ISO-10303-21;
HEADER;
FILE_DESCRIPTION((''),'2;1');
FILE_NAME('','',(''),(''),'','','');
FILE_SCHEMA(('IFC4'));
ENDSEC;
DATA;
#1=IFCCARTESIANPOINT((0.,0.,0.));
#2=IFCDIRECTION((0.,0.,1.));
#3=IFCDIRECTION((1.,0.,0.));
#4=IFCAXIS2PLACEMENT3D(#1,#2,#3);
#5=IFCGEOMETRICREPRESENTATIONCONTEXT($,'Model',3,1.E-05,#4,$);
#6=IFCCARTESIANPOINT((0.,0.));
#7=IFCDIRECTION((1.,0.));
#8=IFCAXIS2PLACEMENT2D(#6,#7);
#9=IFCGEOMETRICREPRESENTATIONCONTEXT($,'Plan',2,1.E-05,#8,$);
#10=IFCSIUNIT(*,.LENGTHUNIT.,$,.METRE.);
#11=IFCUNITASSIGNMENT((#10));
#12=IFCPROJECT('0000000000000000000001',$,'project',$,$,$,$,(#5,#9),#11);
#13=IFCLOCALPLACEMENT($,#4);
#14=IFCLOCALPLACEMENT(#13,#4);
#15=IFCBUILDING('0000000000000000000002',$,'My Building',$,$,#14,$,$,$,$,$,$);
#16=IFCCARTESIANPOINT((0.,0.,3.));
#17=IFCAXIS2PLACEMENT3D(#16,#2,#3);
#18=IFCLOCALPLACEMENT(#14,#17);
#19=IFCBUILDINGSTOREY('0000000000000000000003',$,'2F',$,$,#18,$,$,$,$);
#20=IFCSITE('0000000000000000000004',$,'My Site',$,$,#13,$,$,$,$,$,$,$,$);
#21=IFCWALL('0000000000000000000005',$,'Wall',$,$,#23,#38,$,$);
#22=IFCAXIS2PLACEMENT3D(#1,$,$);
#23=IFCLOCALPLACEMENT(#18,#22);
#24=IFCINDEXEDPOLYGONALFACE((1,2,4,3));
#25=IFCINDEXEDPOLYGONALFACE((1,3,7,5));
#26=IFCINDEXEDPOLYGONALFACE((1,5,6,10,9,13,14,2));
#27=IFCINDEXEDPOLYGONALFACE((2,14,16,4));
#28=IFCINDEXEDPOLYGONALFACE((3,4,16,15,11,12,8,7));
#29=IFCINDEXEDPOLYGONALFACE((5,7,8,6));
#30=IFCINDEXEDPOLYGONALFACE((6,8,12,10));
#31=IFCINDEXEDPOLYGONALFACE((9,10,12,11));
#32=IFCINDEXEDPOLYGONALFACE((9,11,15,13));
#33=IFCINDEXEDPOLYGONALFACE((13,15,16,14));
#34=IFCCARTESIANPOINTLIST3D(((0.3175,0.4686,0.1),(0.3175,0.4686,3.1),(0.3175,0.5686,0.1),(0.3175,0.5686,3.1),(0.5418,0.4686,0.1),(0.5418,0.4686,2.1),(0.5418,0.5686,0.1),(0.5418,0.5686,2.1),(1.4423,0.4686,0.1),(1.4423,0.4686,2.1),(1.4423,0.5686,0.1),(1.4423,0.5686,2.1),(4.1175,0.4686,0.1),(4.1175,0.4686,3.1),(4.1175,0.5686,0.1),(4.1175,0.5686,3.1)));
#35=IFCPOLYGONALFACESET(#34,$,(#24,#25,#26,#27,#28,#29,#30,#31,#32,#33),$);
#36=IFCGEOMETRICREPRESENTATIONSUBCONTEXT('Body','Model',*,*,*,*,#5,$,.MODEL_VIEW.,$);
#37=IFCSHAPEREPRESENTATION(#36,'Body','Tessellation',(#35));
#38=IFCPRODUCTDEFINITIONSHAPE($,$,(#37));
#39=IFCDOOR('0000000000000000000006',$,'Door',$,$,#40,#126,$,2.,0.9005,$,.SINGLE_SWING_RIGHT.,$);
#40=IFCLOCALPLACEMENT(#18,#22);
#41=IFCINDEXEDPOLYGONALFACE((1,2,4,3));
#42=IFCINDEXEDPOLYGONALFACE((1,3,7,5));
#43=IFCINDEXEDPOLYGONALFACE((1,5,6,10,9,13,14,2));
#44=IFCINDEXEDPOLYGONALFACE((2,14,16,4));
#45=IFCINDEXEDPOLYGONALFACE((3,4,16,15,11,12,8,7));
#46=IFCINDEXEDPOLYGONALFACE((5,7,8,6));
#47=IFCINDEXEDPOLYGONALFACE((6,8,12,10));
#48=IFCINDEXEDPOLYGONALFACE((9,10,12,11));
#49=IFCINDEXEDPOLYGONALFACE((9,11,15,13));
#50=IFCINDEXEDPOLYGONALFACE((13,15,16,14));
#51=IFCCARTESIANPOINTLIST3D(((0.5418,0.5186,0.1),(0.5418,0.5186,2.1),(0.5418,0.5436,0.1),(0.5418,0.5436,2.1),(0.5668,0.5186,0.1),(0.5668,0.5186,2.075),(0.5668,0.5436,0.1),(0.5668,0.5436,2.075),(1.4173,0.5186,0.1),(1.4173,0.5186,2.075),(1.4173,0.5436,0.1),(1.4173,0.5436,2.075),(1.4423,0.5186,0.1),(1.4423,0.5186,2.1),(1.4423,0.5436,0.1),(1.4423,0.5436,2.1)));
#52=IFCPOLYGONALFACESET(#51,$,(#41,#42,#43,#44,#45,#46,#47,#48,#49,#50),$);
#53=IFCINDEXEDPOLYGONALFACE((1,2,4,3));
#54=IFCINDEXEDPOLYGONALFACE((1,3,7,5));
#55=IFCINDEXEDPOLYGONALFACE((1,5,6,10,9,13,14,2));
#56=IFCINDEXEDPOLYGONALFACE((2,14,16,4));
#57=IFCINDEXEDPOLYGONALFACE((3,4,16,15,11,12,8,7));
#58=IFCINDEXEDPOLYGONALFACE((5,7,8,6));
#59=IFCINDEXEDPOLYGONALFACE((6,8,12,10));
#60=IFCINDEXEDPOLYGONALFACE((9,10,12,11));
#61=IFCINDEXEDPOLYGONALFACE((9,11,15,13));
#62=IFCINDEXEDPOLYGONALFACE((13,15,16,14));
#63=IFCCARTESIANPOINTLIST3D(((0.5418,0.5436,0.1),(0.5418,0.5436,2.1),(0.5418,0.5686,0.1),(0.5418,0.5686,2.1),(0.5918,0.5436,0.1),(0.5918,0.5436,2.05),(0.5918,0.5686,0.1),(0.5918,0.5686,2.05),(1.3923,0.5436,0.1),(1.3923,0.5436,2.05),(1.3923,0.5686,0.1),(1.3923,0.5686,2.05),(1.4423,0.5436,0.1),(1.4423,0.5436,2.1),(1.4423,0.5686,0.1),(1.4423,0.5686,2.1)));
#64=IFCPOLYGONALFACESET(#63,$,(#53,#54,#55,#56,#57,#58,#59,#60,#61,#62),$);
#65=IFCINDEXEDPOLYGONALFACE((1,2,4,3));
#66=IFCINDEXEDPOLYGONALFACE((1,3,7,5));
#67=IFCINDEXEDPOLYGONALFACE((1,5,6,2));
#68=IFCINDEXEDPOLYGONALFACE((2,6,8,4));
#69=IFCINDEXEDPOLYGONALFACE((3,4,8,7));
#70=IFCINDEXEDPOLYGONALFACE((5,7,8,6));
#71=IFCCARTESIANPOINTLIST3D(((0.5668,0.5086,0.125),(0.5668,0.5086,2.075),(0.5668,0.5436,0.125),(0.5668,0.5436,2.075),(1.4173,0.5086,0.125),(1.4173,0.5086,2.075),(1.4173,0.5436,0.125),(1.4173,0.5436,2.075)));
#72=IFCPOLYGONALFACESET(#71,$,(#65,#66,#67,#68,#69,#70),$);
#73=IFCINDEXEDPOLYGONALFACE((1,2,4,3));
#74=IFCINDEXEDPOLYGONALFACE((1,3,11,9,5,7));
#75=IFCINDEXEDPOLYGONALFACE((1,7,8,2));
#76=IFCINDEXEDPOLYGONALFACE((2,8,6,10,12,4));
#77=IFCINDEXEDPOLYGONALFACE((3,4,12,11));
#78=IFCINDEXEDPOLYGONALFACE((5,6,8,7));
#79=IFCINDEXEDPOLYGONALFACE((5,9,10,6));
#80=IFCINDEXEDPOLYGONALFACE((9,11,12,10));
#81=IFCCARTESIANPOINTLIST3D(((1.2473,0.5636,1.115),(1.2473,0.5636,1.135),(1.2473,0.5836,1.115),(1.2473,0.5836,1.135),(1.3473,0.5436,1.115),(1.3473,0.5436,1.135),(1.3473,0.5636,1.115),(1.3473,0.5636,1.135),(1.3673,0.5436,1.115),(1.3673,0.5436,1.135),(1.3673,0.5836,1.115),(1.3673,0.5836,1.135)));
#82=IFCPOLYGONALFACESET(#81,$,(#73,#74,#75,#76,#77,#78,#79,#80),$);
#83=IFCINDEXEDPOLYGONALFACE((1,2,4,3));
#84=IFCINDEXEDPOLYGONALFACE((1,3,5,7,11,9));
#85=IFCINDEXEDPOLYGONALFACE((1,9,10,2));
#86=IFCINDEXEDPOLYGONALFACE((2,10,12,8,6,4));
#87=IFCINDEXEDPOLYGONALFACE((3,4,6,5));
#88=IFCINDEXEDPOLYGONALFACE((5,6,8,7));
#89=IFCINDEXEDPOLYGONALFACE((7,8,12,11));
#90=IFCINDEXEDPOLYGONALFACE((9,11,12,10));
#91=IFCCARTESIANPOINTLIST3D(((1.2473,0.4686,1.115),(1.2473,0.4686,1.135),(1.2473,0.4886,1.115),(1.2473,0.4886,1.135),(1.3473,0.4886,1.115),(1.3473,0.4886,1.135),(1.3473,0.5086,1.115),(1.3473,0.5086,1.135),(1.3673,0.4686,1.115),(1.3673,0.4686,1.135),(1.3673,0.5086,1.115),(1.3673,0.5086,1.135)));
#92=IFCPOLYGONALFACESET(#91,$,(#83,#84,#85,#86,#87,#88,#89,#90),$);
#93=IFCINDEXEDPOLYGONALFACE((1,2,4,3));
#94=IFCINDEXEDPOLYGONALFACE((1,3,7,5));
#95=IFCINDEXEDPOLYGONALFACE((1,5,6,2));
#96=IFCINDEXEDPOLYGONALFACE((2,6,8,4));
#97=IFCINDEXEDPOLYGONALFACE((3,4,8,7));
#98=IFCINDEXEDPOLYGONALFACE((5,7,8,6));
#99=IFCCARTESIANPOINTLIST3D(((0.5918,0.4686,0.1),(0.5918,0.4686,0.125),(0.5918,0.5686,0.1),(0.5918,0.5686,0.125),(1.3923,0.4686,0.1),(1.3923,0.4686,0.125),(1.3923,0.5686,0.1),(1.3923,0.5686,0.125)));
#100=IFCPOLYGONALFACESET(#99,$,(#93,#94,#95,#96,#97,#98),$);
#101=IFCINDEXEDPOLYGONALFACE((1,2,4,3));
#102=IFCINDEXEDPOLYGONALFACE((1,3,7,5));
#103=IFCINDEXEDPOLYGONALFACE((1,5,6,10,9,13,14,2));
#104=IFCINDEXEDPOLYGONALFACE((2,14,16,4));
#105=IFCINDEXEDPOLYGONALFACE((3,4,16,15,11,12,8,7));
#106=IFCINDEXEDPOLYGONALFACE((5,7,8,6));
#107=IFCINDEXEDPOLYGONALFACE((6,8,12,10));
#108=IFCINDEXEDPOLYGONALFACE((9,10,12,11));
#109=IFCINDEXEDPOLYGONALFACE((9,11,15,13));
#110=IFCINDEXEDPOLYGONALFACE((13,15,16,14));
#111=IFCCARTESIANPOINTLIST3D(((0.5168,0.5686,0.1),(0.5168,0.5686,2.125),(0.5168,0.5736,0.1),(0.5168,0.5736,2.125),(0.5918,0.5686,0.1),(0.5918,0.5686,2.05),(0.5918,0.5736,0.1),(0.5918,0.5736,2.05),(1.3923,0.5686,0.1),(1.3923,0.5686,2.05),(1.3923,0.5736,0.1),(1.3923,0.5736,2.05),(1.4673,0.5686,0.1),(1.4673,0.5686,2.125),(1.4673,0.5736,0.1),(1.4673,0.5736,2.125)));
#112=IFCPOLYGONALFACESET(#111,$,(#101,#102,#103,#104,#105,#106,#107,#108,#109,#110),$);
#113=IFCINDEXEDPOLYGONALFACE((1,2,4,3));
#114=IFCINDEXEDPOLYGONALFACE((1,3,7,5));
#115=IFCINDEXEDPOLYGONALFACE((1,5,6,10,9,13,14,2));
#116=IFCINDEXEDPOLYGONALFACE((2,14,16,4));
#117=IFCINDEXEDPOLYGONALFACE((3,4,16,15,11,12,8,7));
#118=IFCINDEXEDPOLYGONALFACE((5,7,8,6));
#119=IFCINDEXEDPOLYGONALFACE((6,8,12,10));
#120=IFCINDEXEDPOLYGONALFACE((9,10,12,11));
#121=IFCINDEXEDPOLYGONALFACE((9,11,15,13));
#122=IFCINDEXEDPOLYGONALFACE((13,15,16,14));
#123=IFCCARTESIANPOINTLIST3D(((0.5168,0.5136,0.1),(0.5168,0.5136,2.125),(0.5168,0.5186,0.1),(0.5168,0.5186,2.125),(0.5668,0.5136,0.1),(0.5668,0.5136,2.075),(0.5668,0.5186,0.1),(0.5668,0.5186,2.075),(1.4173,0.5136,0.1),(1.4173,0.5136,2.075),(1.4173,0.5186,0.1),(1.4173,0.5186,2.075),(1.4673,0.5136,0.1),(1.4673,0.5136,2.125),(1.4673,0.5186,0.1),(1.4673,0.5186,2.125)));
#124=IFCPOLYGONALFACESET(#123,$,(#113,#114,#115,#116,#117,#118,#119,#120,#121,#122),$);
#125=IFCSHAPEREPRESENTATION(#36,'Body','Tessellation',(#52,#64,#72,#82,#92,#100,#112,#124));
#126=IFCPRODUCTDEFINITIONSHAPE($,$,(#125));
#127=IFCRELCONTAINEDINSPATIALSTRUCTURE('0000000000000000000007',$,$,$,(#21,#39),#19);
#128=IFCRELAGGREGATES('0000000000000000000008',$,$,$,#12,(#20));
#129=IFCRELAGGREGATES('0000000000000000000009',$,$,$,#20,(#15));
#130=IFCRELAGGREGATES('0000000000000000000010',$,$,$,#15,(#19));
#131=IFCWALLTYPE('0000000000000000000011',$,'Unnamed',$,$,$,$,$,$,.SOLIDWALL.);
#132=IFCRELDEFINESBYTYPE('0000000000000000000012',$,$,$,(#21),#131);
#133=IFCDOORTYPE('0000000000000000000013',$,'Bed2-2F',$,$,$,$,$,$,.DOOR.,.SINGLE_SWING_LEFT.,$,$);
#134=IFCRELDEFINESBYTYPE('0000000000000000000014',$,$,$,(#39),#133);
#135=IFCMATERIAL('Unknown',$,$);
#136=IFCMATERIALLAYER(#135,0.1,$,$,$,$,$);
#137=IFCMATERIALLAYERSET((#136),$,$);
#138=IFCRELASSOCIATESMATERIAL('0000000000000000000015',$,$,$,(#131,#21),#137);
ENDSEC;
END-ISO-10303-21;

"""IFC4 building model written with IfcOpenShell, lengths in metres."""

from ifc_helpers import new_model, entity, si_unit, frame, origin_with_axes, origin_2d_with_axis, place, context, subcontext, project, spatial, line, indexed_curve, outline, extrude, shape, source, transform, mapped, material, layer, layer_set, layer_usage, type_object, type_shapes, element, fill, save


model = new_model("IFC4")

# Units and contexts
model_context = context("Model", 3, precision=1e-05, world=origin_with_axes())
plan_context = context("Plan", 2, precision=1e-05, world=origin_2d_with_axis())
body_context_1 = subcontext(model_context, "Body", "Model", "MODEL_VIEW")
body_context_2 = subcontext(plan_context, "Body", "Plan", "PLAN_VIEW")
ifc_project = project(units=[si_unit("LENGTHUNIT", "METRE")], contexts=[model_context, plan_context])

# Site, building, storey
site_placement = place(None, origin_with_axes())
site = spatial("IfcSite", under=ifc_project, at=site_placement, Name="My Site")
building_placement = place(site_placement, origin_with_axes())
building = spatial("IfcBuilding", under=site, at=building_placement, Name="My Building")
storey_placement = place(building_placement, frame((0.0, 0.0, 3.0), z_axis=(0.0, 0.0, 1.0), x_axis=(1.0, 0.0, 0.0)))
storey = spatial("IfcBuildingStorey", under=building, at=storey_placement, Name="2F")

# Shared definitions
ifc_material = material(Name="Unknown")

# Shared definitions
ifc_layer_1 = layer(ifc_material, 0.1)
ifc_layer_set_1 = layer_set([ifc_layer_1])
wall_type = type_object("IfcWallType", Name="Unnamed", PredefinedType="SOLIDWALL", material=ifc_layer_set_1)

# Wall, opening, door
ifc_layer_usage_1 = layer_usage(ifc_layer_set_1, "AXIS2", "POSITIVE", 0.0)
wall_1_placement = place(storey_placement, frame((0.2175, 0.4686, 0.1), z_axis=(0.0, 0.0, 1.0), x_axis=(1.0, 0.0, 0.0)))
wall_1 = element("IfcWall", 1, at=wall_1_placement, inside=storey, type_object=wall_type, material=ifc_layer_usage_1, Name="Wall", context=body_context_1, shape_type="SweptSolid", body=[
    extrude(outline(indexed_curve([(0.1, 0.0), (0.1, 0.1), (3.9, 0.1), (3.9, 0.0)], segments=[line(1, 2, 3, 4, 1)])), origin_with_axes(), (0.0, 0.0, 1.0), 3.0),
])
shared_shape_1 = source(origin_with_axes(), body_context_1, "Body", "SweptSolid", [
    extrude(outline(indexed_curve([(0.0, 0.0), (0.9005, 0.0), (0.9005, 2.0), (0.0, 2.0)], segments=[line(1, 2, 3, 4, 1)])), frame((0.0, -0.6, 0.0), z_axis=(0.0, -1.0, 0.0), x_axis=(1.0, 0.0, 0.0)), (0.0, 0.0, -1.0), 1.2),
])
opening_1_placement = place(wall_1_placement, frame((1.2248, 0.1, 0.0), z_axis=(0.0, 0.0, 1.0), x_axis=(-1.0, 0.0, 0.0)))
opening_1 = element("IfcOpeningElement", 2, at=opening_1_placement, cuts=wall_1, PredefinedType="OPENING", context=body_context_1, shape_type="MappedRepresentation", body=[
    mapped(shared_shape_1, transform((0.0, 0.0, 0.0), x_axis=(1.0, 0.0, 0.0), y_axis=(0.0, 1.0, 0.0), z_axis=(0.0, 0.0, 1.0), scale=1.0)),
])
door_type_1 = type_object("IfcDoorType", Name="Bed2-2F", OperationType="SINGLE_SWING_LEFT", PredefinedType="DOOR")
shared_shape_2 = source(origin_with_axes(), body_context_1, "Body", "SweptSolid", [
    extrude(outline(indexed_curve([(0.0, 0.0), (0.0, 2.0), (0.9005, 2.0), (0.9005, 0.0), (0.8755, 0.0), (0.8755, 1.975), (0.025, 1.975), (0.025, 0.0)], segments=[line(1, 2, 3, 4, 5, 6, 7, 8, 1)])), frame((0.0, 0.025, 0.0), z_axis=(0.0, -1.0, 0.0), x_axis=(1.0, 0.0, 0.0)), (0.0, 0.0, -1.0), 0.025),
    extrude(outline(indexed_curve([(0.0, 0.0), (0.0, 2.0), (0.9005, 2.0), (0.9005, 0.0), (0.8505, 0.0), (0.8505, 1.95), (0.05, 1.95), (0.05, 0.0)], segments=[line(1, 2, 3, 4, 5, 6, 7, 8, 1)])), frame((0.0, 0.0, 0.0), z_axis=(0.0, -1.0, 0.0), x_axis=(1.0, 0.0, 0.0)), (0.0, 0.0, -1.0), 0.025),
    extrude(outline(indexed_curve([(0.0, 0.0), (0.8505, 0.0), (0.8505, 0.035), (0.0, 0.035)], segments=[line(1, 2, 3, 4, 1)])), frame((0.025, 0.025, 0.025), z_axis=(0.0, 0.0, 1.0), x_axis=(1.0, 0.0, 0.0)), (0.0, 0.0, 1.0), 1.95),
    extrude(outline(indexed_curve([(0.0, 0.0), (0.0, -0.04), (0.12, -0.04), (0.12, -0.02), (0.02, -0.02), (0.02, 0.0)], segments=[line(1, 2, 3, 4, 5, 6, 1)])), frame((0.075, 0.025, 1.015), z_axis=(0.0, 0.0, 1.0), x_axis=(1.0, 0.0, 0.0)), (0.0, 0.0, 1.0), 0.02),
    extrude(outline(indexed_curve([(0.0, 0.0), (0.0, 0.04), (0.12, 0.04), (0.12, 0.02), (0.02, 0.02), (0.02, 0.0)], segments=[line(1, 2, 3, 4, 5, 6, 1)])), frame((0.075, 0.06, 1.015), z_axis=(0.0, 0.0, 1.0), x_axis=(1.0, 0.0, 0.0)), (0.0, 0.0, 1.0), 0.02),
    extrude(outline(indexed_curve([(0.0, 0.0), (0.8005, 0.0), (0.8005, 0.1), (0.0, 0.1)], segments=[line(1, 2, 3, 4, 1)])), frame((0.05, 0.0, 0.0), z_axis=(0.0, 0.0, 1.0), x_axis=(1.0, 0.0, 0.0)), (0.0, 0.0, 1.0), 0.025),
    extrude(outline(indexed_curve([(0.0, 0.0), (0.0, 2.025), (0.9505, 2.025), (0.9505, 0.0), (0.8755, 0.0), (0.8755, 1.95), (0.075, 1.95), (0.075, 0.0)], segments=[line(1, 2, 3, 4, 5, 6, 7, 8, 1)])), frame((-0.025, -0.005, 0.0), z_axis=(0.0, -1.0, 0.0), x_axis=(1.0, 0.0, 0.0)), (0.0, 0.0, -1.0), 0.005),
    extrude(outline(indexed_curve([(0.0, 0.0), (0.0, 2.025), (0.9505, 2.025), (0.9505, 0.0), (0.9005, 0.0), (0.9005, 1.975), (0.05, 1.975), (0.05, 0.0)], segments=[line(1, 2, 3, 4, 5, 6, 7, 8, 1)])), frame((-0.025, 0.05, 0.0), z_axis=(0.0, -1.0, 0.0), x_axis=(1.0, 0.0, 0.0)), (0.0, 0.0, -1.0), 0.005),
])
shared_shape_3 = source(origin_with_axes(), body_context_2, "Body", "Curve2D", [
    entity("IfcIndexedPolyCurve", entity("IfcCartesianPointList2D", [[0.0, 0.0], [0.0, 0.05], [0.025, 0.05], [0.025, 0.025], [0.05, 0.025], [0.05, 0.0]]), [entity("IfcLineIndex", [1, 2, 3, 4, 5, 6, 1])]),
    entity("IfcIndexedPolyCurve", entity("IfcCartesianPointList2D", [[0.9005, 0.0], [0.9005, 0.05], [0.8755, 0.05], [0.8755, 0.025], [0.8505, 0.025], [0.8505, 0.0]]), [entity("IfcLineIndex", [1, 2, 3, 4, 5, 6, 1])]),
    entity("IfcTrimmedCurve", entity("IfcEllipse", entity("IfcAxis2Placement2D", entity("IfcCartesianPoint", [0.8405, 0.05]), entity("IfcDirection", [1.0, 0.0])), 0.8155, 0.8505), [entity("IfcCartesianPoint", [0.8405, 0.9005])], [entity("IfcCartesianPoint", [0.025, 0.05])], True, "CARTESIAN"),
    entity("IfcIndexedPolyCurve", entity("IfcCartesianPointList2D", [[0.8755, 0.05], [0.8405, 0.05], [0.8405, 0.9005], [0.8755, 0.9005]]), [entity("IfcLineIndex", [1, 2, 3, 4, 1])]),
])
type_shapes(door_type_1, [shared_shape_2, shared_shape_3])
door_1_placement = place(opening_1_placement, frame((0.0, 0.0, 0.0), z_axis=(0.0, 0.0, 1.0), x_axis=(1.0, 0.0, 0.0)))
door_1 = element("IfcDoor", 3, at=door_1_placement, inside=storey, type_object=door_type_1, Name="Door", OperationType="SINGLE_SWING_RIGHT", OverallHeight=2.0, OverallWidth=0.9005, shapes=[
    shape(body_context_1, "Body", "MappedRepresentation", [mapped(shared_shape_2, transform((0.0, 0.0, 0.0), x_axis=(1.0, 0.0, 0.0), y_axis=(0.0, 1.0, 0.0), z_axis=(0.0, 0.0, 1.0), scale=1.0))]),
    shape(body_context_2, "Body", "MappedRepresentation", [mapped(shared_shape_3, transform((0.0, 0.0, 0.0), x_axis=(1.0, 0.0, 0.0), y_axis=(0.0, 1.0, 0.0), z_axis=(0.0, 0.0, 1.0), scale=1.0))]),
])
fill(opening_1, door_1)

save(model, "model.ifc")
